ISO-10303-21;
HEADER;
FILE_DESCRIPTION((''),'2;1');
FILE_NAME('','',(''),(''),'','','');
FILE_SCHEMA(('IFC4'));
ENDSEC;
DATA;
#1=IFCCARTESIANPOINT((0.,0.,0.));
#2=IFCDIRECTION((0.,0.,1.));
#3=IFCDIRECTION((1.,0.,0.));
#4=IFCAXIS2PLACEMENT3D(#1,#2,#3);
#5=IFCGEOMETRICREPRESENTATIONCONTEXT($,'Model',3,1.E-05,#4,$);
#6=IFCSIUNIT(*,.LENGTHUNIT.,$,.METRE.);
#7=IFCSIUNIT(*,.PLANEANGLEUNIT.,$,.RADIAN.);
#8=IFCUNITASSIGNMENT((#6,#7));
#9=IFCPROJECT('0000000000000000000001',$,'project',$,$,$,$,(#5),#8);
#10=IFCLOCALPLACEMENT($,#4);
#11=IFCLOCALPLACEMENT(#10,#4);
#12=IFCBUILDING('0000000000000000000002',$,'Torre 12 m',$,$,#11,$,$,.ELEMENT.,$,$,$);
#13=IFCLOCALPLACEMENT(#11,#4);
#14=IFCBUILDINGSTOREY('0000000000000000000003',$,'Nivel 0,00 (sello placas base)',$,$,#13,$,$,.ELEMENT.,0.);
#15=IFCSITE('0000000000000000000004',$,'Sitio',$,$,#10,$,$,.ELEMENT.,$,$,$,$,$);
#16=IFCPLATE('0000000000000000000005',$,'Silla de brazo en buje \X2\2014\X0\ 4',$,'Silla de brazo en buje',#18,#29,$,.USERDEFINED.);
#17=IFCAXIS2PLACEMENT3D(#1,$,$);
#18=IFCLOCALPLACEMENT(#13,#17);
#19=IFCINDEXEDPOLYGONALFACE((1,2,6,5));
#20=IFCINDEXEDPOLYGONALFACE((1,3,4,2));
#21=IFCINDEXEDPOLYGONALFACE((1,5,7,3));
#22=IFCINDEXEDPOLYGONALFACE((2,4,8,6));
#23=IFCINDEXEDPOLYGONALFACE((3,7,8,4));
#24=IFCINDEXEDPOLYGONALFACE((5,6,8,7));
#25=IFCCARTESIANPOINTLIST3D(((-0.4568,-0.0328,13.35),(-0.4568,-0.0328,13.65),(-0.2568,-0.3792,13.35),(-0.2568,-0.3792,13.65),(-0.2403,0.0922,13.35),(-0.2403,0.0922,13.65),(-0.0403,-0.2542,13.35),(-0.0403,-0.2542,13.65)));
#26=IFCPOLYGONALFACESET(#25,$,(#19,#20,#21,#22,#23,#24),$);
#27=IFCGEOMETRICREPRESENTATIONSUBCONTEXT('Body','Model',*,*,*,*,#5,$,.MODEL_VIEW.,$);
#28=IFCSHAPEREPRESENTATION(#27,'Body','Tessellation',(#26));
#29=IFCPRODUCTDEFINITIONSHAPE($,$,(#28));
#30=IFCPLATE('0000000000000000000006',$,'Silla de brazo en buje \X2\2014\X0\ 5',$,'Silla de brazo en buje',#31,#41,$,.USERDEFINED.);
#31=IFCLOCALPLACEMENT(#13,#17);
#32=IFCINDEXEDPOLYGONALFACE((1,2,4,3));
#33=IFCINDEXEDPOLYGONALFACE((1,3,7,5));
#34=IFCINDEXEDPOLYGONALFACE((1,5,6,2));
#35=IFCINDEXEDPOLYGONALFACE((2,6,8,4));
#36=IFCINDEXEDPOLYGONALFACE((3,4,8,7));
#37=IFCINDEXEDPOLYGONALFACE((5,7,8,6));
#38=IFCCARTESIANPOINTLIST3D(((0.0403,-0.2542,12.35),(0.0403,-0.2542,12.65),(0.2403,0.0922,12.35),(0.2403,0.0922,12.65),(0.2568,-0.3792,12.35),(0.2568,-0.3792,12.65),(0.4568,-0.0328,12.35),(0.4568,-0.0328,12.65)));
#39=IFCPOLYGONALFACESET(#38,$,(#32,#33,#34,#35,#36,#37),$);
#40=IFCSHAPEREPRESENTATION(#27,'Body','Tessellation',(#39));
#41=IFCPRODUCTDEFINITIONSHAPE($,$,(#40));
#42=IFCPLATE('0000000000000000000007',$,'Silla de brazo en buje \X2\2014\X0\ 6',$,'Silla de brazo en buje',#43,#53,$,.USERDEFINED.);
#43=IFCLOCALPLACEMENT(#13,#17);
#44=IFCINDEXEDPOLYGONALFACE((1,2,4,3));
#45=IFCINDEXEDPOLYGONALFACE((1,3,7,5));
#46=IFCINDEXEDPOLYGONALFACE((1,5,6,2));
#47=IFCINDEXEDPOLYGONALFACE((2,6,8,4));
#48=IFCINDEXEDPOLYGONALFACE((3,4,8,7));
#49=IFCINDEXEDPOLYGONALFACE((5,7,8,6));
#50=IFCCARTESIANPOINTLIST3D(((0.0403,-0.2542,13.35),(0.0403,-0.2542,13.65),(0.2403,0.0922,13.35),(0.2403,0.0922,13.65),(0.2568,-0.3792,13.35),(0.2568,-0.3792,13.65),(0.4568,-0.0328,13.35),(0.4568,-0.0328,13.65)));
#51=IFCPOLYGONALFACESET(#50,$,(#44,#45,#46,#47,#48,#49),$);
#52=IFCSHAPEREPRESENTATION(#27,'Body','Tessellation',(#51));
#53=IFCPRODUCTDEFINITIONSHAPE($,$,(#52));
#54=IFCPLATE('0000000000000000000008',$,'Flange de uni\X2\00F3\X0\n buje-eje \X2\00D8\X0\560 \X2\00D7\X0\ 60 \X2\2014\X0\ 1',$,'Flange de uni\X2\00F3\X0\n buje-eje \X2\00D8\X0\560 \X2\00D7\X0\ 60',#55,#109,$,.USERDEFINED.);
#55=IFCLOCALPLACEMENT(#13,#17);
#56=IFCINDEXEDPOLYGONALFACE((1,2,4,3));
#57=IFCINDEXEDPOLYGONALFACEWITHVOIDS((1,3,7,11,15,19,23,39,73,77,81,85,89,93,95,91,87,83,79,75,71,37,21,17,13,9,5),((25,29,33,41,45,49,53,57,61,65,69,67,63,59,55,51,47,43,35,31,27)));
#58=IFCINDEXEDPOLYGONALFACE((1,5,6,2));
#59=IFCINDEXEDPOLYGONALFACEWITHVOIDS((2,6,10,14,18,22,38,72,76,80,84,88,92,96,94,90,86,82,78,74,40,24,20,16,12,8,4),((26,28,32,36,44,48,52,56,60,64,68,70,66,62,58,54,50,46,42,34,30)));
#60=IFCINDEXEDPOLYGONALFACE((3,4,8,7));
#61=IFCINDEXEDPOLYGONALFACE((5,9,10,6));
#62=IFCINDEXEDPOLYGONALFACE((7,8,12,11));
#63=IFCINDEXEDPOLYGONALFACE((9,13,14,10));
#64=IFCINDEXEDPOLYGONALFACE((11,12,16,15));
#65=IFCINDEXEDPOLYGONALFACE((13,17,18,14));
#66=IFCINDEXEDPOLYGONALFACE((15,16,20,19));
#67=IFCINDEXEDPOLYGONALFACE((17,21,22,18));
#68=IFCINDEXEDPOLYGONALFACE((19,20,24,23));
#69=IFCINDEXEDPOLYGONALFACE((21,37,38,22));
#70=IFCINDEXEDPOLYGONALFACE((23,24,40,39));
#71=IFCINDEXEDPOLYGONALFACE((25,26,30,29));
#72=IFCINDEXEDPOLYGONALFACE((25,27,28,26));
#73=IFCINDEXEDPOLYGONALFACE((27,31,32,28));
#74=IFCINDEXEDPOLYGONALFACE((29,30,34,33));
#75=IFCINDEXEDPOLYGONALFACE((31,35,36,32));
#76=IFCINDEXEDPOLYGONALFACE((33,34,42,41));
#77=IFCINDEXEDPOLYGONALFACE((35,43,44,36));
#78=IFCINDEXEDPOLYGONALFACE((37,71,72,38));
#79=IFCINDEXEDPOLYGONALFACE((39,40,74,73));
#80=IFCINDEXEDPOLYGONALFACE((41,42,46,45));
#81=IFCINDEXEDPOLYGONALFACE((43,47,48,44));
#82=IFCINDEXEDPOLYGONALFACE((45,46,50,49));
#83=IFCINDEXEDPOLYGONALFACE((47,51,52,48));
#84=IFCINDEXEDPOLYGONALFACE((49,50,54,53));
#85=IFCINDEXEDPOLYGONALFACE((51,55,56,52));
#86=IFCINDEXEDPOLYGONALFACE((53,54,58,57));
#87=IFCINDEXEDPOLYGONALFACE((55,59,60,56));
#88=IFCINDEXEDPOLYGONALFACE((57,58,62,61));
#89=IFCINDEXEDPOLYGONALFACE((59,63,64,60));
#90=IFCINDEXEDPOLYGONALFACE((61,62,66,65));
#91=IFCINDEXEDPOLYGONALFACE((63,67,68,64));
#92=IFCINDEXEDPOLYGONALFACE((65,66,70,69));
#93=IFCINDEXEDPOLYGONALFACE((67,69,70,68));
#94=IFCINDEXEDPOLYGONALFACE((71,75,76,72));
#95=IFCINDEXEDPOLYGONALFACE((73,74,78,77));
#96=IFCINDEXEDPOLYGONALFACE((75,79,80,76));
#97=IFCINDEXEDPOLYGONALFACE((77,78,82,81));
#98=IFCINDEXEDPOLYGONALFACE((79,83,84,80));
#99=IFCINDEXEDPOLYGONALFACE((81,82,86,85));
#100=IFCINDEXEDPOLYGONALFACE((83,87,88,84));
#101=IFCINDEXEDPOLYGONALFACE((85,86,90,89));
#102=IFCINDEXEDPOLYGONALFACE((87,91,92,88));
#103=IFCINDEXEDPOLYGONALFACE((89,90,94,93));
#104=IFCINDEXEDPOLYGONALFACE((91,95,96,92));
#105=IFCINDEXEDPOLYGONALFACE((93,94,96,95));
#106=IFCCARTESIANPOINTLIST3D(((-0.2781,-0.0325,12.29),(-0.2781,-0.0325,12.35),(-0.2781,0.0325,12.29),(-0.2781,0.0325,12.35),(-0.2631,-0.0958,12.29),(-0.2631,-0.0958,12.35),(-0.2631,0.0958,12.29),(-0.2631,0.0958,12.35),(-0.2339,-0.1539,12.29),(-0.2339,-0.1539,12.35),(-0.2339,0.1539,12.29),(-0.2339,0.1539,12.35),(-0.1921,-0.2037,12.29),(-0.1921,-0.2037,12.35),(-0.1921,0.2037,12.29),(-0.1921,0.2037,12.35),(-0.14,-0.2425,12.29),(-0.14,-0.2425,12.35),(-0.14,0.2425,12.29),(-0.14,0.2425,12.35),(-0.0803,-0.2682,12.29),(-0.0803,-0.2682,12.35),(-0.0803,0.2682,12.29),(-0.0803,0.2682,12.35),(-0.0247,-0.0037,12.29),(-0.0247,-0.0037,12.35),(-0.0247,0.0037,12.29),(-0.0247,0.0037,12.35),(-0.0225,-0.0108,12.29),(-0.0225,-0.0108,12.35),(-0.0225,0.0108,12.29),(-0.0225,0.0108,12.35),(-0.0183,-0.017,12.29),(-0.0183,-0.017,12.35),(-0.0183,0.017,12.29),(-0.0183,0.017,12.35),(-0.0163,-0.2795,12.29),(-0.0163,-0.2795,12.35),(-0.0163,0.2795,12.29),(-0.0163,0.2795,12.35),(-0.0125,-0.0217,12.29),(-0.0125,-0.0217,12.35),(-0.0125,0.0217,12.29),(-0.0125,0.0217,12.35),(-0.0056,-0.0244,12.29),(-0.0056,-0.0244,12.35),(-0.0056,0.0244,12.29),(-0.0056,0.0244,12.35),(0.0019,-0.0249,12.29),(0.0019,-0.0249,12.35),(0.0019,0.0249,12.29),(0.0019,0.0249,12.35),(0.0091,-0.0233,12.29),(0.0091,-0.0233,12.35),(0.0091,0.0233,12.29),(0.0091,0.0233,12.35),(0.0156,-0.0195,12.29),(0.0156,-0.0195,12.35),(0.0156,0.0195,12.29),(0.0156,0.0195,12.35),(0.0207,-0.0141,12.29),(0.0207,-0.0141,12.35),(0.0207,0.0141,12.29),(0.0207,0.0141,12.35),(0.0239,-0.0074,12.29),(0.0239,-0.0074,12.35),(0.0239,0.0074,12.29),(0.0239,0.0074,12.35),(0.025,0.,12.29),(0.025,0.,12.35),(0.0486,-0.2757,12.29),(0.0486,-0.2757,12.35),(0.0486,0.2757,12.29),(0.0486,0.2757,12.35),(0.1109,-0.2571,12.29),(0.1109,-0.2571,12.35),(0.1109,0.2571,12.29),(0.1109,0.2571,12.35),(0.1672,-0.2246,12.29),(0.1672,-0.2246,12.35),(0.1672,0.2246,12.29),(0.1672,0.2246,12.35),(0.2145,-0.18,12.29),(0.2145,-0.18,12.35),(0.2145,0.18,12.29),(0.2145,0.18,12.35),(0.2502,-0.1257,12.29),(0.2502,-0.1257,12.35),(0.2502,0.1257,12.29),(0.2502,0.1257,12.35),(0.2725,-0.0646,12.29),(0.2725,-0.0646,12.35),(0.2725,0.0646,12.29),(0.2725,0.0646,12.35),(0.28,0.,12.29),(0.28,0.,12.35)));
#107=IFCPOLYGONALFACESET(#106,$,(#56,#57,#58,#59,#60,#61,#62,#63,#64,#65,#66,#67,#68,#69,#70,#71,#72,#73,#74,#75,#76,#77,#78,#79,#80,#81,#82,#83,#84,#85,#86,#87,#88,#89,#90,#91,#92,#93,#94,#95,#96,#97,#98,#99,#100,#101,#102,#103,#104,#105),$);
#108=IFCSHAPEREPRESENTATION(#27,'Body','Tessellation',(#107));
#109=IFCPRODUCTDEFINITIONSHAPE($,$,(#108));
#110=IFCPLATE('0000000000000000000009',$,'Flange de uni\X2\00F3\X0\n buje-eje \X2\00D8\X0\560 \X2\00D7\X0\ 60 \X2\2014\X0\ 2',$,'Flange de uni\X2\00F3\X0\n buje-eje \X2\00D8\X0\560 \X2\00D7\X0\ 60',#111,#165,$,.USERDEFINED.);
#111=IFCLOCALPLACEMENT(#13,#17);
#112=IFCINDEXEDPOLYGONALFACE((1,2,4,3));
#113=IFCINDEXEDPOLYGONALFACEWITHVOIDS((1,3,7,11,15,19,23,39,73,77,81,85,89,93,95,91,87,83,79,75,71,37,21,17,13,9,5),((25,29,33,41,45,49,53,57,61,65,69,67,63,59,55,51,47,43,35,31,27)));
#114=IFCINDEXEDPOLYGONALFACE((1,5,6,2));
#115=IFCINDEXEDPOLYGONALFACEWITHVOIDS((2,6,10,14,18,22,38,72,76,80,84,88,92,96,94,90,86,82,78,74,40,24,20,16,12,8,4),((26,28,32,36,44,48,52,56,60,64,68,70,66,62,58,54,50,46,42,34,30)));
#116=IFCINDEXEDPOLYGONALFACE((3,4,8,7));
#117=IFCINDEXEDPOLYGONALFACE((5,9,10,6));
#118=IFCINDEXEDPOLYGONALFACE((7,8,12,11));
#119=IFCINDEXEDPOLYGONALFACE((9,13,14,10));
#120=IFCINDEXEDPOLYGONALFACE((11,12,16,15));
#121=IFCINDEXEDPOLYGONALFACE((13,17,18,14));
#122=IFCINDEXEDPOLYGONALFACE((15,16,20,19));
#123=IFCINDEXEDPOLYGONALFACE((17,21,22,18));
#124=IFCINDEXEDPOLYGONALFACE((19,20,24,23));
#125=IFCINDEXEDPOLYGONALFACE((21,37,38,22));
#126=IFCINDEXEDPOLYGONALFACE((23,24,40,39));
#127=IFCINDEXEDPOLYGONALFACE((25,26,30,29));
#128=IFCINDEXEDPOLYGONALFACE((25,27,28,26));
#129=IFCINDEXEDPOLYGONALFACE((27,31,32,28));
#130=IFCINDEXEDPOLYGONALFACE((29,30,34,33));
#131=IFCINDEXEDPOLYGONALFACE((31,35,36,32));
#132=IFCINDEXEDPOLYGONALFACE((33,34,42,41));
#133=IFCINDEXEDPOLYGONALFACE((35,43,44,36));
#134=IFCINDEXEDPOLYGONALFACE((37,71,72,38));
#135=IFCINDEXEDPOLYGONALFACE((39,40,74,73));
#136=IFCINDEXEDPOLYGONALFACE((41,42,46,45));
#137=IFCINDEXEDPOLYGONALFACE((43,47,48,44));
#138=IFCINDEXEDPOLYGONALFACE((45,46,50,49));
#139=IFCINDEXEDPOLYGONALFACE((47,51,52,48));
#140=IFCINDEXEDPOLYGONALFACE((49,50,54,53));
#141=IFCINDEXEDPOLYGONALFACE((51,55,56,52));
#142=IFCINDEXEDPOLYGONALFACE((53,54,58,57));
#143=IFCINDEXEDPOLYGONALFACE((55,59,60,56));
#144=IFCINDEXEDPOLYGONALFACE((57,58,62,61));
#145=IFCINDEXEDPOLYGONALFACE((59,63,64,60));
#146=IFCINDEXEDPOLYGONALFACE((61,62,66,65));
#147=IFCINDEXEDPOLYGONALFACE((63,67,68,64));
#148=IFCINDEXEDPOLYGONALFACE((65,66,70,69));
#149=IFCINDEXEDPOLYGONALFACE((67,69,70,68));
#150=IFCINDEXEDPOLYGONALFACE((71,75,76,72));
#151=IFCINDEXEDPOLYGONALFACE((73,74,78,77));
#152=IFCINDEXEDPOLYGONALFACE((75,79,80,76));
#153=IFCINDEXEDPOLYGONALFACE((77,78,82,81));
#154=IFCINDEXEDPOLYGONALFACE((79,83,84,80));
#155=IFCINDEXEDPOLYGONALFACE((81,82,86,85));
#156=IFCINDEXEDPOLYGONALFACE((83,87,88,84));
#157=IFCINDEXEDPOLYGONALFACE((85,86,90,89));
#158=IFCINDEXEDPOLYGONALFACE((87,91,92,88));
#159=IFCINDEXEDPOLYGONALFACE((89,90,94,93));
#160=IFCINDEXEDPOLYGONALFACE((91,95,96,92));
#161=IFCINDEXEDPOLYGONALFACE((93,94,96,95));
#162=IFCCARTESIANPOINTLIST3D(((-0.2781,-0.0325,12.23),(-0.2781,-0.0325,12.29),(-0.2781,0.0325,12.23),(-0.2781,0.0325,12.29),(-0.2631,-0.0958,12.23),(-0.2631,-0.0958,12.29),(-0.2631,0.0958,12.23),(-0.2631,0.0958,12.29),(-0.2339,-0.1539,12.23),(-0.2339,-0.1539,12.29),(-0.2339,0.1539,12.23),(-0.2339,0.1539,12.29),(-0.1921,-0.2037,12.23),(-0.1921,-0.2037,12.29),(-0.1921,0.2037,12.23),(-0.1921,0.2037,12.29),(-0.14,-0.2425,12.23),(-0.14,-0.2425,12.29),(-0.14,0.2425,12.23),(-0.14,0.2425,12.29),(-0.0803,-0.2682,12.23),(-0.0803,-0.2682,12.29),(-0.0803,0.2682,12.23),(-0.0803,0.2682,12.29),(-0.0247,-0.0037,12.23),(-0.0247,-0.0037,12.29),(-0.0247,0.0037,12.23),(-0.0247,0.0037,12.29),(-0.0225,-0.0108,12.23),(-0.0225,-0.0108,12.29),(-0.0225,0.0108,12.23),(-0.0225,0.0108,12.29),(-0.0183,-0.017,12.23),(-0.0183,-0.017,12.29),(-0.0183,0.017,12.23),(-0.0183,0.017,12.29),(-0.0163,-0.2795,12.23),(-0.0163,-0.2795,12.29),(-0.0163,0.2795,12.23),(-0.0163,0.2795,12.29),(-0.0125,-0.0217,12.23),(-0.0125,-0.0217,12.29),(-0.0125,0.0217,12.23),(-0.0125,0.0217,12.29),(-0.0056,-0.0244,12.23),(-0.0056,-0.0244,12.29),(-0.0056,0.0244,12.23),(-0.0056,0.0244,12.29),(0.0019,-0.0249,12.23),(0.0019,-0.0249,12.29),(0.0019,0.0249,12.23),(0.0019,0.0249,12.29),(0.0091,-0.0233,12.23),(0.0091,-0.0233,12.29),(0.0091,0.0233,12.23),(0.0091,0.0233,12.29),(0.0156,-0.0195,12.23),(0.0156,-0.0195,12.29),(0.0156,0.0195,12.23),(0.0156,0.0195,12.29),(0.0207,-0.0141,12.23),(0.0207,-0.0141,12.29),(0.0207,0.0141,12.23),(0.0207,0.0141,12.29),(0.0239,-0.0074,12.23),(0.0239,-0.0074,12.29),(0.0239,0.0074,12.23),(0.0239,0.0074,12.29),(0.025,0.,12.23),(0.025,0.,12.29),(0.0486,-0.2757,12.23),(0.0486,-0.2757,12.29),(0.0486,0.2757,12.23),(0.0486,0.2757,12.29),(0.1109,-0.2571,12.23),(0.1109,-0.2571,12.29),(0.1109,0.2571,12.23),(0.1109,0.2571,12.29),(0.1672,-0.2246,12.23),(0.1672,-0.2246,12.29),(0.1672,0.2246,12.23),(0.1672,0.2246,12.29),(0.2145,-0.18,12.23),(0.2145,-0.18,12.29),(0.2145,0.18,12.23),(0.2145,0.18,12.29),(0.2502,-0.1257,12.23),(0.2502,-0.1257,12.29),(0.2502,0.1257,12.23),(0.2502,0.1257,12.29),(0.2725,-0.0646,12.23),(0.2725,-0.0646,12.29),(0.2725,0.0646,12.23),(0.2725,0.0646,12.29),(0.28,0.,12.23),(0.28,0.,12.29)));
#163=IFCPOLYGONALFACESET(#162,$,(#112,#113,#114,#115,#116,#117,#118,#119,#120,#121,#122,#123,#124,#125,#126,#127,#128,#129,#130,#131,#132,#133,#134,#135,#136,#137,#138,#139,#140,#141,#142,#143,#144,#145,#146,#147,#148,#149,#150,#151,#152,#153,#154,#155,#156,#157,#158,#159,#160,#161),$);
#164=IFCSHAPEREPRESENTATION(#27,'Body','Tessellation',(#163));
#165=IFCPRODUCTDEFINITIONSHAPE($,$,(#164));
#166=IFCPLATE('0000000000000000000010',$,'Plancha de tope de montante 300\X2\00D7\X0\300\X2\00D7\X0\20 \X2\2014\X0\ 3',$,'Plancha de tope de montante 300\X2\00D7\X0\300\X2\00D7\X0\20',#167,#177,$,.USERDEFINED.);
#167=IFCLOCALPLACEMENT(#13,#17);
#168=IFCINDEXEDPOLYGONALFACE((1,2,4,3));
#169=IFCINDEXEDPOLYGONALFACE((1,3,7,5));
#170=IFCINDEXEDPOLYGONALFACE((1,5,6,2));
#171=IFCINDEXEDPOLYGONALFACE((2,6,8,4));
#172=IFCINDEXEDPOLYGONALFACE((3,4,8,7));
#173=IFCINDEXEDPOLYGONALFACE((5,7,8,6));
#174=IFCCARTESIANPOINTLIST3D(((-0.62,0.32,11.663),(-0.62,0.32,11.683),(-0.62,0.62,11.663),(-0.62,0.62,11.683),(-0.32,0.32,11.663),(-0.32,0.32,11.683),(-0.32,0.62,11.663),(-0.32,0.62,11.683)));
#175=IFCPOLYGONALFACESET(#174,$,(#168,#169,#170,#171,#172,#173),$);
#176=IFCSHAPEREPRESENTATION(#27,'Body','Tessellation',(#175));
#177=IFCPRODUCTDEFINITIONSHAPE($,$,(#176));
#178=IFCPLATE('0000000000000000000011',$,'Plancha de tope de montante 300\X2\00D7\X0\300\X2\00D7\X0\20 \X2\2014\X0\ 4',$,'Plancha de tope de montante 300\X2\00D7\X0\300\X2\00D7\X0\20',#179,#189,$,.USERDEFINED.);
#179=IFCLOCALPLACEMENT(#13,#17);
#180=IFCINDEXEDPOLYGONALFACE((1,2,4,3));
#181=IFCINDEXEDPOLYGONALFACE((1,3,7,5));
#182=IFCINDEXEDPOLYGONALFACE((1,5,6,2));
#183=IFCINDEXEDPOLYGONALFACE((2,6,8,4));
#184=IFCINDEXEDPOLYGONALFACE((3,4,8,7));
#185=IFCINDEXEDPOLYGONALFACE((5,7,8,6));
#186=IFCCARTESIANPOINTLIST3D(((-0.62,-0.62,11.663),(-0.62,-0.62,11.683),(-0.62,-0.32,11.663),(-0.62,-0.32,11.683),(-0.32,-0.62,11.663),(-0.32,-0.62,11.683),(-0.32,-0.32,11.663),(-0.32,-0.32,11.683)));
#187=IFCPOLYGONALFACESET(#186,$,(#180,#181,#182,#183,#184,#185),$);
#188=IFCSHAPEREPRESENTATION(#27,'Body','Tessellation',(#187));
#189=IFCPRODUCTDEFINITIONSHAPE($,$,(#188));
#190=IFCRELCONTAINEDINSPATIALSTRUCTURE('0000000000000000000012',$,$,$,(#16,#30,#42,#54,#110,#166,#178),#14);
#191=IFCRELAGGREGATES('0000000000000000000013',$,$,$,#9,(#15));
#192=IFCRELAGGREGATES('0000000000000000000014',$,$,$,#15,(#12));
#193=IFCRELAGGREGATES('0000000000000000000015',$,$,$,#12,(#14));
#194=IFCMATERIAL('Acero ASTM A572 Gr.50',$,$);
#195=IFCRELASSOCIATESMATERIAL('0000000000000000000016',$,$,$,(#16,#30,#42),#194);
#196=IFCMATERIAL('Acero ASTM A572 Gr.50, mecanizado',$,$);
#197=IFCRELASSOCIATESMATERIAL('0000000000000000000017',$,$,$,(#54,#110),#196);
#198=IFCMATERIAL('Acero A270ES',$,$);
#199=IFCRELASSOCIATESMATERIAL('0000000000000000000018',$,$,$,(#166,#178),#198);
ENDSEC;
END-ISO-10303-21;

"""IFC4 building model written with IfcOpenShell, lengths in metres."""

from ifc_helpers import new_model, si_unit, frame, origin, origin_with_axes, origin_2d, place, context, subcontext, project, spatial, rectangle, hollow_circle, extrude, material, element, save


model = new_model("IFC4")

# Units and contexts
model_context = context("Model", 3, precision=1e-05, world=origin_with_axes())
body_context = subcontext(model_context, "Body", "Model", "MODEL_VIEW")
ifc_project = project(units=[si_unit("LENGTHUNIT", "METRE"), si_unit("PLANEANGLEUNIT", "RADIAN")], contexts=[model_context])

# Site, building, storey
site_placement = place(None, origin_with_axes())
site = spatial("IfcSite", under=ifc_project, at=site_placement, Name="Sitio", CompositionType="ELEMENT")
building_placement = place(site_placement, origin_with_axes())
building = spatial("IfcBuilding", under=site, at=building_placement, Name="Torre 12 m", CompositionType="ELEMENT")
storey_placement = place(building_placement, origin_with_axes())
storey = spatial("IfcBuildingStorey", under=building, at=storey_placement, Name="Nivel 0,00 (sello placas base)", CompositionType="ELEMENT", Elevation=0.0)

# Shared definitions
ifc_material_1 = material(Name="Acero ASTM A572 Gr.50")

# Plates
for number, where, z_axis, x_axis, name in (
    (1, (-0.2485, -0.1435, 13.35), (0.0, 0.0, 1.0), (-0.866025, -0.5, 0.0), "Silla de brazo en buje — 4"),
    (2, (0.2485, -0.1435, 12.35), (0.0, 0.0, 1.0), (0.866025, -0.5, 0.0), "Silla de brazo en buje — 5"),
    (3, (0.2485, -0.1435, 13.35), (0.0, 0.0, 1.0), (0.866025, -0.5, 0.0), "Silla de brazo en buje — 6"),
):
    element("IfcPlate", number, at=place(storey_placement, frame(where, z_axis=z_axis, x_axis=x_axis)), inside=storey, material=ifc_material_1, Name=name, ObjectType="Silla de brazo en buje", PredefinedType="USERDEFINED", context=body_context, shape_type="SweptSolid", body=[
        extrude(rectangle(XDim=0.25, YDim=0.4, at=origin_2d()), origin(), (0.0, 0.0, 1.0), 0.3),
    ])
ifc_material_2 = material(Name="Acero ASTM A572 Gr.50, mecanizado")
for number, where, z_axis, x_axis, name in (
    (4, (0.0, 0.0, 12.29), (0.0, 0.0, 1.0), (1.0, 0.0, 0.0), "Flange de unión buje-eje Ø560 × 60 — 1"),
    (5, (0.0, 0.0, 12.23), (0.0, 0.0, 1.0), (1.0, 0.0, 0.0), "Flange de unión buje-eje Ø560 × 60 — 2"),
):
    element("IfcPlate", number, at=place(storey_placement, frame(where, z_axis=z_axis, x_axis=x_axis)), inside=storey, material=ifc_material_2, Name=name, ObjectType="Flange de unión buje-eje Ø560 × 60", PredefinedType="USERDEFINED", context=body_context, shape_type="SweptSolid", body=[
        extrude(hollow_circle(Radius=0.28, WallThickness=0.255, at=origin_2d()), origin(), (0.0, 0.0, 1.0), 0.06),
    ])
ifc_material_3 = material(Name="Acero A270ES")
for number, where, z_axis, x_axis, name in (
    (6, (-0.47, 0.47, 11.663), (0.0, 0.0, 1.0), (1.0, 0.0, 0.0), "Plancha de tope de montante 300×300×20 — 3"),
    (7, (-0.47, -0.47, 11.663), (0.0, 0.0, 1.0), (1.0, 0.0, 0.0), "Plancha de tope de montante 300×300×20 — 4"),
):
    element("IfcPlate", number, at=place(storey_placement, frame(where, z_axis=z_axis, x_axis=x_axis)), inside=storey, material=ifc_material_3, Name=name, ObjectType="Plancha de tope de montante 300×300×20", PredefinedType="USERDEFINED", context=body_context, shape_type="SweptSolid", body=[
        extrude(rectangle(XDim=0.3, YDim=0.3, at=origin_2d()), origin(), (0.0, 0.0, 1.0), 0.02),
    ])

save(model, "model.ifc")
